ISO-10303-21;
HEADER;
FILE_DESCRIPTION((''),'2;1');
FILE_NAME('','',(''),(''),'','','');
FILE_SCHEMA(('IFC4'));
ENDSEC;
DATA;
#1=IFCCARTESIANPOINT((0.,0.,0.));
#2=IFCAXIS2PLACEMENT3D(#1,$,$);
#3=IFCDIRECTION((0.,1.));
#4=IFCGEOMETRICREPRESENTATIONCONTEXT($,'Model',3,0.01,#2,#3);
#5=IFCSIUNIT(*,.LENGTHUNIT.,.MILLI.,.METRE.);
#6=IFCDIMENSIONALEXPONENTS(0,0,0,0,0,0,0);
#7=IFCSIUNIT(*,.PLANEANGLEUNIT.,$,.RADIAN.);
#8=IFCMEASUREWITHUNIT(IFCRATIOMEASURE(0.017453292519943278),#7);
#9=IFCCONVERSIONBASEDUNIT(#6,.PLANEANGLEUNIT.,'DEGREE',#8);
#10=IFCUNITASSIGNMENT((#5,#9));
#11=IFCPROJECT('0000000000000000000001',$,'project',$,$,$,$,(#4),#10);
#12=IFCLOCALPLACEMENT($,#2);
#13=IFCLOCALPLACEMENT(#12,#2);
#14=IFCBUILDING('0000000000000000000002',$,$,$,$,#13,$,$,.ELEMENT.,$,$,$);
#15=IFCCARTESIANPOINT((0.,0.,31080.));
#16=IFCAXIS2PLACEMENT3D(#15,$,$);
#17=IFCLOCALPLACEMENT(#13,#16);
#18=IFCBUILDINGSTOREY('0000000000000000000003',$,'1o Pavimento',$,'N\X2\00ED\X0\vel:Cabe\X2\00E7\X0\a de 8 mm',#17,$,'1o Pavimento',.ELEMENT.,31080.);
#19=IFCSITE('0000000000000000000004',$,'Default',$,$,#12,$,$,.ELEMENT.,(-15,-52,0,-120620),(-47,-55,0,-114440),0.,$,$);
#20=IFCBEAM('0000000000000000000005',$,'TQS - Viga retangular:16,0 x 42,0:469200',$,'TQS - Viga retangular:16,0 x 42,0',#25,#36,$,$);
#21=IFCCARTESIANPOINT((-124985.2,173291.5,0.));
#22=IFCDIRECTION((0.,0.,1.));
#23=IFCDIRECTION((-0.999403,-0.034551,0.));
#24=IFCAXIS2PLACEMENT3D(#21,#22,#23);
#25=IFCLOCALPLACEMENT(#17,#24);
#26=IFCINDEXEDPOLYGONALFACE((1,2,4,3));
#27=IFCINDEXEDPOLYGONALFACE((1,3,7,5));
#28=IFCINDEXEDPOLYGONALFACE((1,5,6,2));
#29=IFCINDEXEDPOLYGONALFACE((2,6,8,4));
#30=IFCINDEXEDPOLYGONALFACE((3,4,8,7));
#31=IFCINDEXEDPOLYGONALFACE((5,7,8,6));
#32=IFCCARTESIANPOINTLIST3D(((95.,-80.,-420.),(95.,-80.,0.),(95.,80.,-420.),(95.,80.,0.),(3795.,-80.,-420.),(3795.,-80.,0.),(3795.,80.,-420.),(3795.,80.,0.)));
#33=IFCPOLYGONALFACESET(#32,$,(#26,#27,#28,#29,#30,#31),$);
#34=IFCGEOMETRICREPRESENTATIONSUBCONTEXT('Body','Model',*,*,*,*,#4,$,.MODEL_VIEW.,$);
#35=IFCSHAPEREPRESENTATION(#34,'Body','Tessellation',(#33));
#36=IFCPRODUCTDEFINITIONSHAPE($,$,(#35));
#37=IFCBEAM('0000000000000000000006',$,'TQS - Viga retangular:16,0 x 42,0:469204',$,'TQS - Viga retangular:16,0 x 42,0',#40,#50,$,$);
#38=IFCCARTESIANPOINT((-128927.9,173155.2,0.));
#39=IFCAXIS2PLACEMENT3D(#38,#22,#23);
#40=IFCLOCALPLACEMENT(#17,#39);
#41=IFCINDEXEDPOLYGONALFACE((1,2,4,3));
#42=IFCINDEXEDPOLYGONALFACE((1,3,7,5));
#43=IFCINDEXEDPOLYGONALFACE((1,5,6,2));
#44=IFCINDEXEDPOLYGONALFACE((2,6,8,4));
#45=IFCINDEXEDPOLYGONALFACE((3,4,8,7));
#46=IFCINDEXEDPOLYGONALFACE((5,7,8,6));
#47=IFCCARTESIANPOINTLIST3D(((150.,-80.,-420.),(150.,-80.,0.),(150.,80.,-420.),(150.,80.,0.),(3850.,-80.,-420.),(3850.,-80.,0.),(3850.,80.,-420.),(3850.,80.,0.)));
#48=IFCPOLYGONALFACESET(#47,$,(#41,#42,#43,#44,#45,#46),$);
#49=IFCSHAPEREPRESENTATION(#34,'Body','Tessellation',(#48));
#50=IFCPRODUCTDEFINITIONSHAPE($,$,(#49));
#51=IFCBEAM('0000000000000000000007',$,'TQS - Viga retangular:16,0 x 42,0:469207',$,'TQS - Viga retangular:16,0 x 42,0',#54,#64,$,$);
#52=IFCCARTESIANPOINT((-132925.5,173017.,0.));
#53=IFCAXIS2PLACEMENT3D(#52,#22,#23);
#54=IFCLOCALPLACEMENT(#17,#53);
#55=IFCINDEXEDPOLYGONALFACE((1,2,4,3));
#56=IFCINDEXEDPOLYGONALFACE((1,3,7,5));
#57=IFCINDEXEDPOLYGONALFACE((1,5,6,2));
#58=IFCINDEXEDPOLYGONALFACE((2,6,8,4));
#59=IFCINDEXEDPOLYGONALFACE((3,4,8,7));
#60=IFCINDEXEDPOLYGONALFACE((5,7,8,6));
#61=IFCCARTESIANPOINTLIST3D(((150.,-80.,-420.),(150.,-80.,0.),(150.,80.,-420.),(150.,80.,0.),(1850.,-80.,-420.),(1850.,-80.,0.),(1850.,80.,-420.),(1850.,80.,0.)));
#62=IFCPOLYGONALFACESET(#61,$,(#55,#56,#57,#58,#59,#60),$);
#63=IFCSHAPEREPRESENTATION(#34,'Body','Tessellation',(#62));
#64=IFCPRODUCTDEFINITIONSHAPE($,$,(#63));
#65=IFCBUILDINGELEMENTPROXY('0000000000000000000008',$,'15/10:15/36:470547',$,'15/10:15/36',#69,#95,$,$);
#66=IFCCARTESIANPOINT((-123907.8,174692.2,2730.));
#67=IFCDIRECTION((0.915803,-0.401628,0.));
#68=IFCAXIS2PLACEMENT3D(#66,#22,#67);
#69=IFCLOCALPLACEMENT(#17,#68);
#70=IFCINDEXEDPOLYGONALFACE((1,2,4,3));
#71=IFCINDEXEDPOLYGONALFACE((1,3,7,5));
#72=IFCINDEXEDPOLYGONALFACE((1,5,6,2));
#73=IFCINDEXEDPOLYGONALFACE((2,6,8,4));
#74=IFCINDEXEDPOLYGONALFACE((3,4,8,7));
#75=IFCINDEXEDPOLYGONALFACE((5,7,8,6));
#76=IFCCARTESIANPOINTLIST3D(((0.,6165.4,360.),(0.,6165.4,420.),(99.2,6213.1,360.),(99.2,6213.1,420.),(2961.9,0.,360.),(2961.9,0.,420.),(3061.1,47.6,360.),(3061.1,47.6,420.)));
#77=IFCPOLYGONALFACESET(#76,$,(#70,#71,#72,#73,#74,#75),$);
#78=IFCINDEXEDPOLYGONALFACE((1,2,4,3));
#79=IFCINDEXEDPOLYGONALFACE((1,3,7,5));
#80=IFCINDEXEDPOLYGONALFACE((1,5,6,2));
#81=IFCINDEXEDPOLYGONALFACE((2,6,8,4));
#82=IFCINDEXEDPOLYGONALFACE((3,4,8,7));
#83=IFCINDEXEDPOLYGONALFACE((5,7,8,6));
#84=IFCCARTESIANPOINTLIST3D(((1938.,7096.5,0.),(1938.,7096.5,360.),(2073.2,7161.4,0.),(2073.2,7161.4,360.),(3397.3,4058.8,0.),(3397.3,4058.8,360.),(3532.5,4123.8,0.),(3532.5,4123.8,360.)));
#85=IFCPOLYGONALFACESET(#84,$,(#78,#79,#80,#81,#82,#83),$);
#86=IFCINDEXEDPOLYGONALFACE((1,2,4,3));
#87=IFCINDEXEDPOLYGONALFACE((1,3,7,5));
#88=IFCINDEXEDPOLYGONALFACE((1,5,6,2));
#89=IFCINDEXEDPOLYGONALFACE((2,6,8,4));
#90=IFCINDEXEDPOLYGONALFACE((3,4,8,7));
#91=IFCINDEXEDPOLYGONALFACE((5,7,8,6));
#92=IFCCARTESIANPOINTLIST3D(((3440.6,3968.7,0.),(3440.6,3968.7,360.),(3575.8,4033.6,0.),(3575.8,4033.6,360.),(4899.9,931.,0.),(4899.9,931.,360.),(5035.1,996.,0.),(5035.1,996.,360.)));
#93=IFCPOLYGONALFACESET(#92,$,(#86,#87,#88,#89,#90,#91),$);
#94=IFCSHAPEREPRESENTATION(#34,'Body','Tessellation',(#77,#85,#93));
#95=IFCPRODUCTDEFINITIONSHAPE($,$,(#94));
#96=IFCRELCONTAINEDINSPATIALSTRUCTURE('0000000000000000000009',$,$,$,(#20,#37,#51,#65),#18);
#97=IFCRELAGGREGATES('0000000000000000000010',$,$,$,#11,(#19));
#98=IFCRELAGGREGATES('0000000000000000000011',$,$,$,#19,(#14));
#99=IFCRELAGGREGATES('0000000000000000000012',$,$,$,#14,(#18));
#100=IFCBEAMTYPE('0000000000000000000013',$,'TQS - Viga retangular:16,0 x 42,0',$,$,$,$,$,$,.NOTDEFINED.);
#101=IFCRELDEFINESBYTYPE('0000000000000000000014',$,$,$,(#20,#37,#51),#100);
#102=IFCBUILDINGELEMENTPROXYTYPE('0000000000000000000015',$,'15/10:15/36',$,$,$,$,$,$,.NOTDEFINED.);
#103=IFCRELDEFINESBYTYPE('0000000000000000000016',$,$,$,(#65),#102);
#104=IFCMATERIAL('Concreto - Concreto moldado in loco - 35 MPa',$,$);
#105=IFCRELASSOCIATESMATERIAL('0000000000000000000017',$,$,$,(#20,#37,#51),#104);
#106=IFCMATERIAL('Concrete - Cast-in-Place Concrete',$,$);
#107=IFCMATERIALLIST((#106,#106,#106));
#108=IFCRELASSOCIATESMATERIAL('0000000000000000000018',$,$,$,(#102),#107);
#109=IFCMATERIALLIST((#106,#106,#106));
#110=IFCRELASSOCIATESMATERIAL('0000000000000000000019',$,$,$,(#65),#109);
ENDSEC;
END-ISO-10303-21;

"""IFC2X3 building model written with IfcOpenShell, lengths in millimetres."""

from ifc_helpers import new_model, entity, si_unit, converted_unit, direction, frame, frame_2d, origin, origin_2d_with_axis, place, context, subcontext, project, spatial, rectangle, extrude, source, transform, mapped, material, material_list, type_object, type_shapes, element, save


model = new_model("IFC2X3")

# Units and contexts
model_context = context("Model", 3, precision=0.01, world=origin(), true_north=direction((0.0, 1.0)))
body_context = subcontext(model_context, "Body", "Model", "MODEL_VIEW")
ifc_project = project(units=[si_unit("LENGTHUNIT", "METRE", prefix="MILLI"), converted_unit("PLANEANGLEUNIT", "DEGREE", entity("IfcRatioMeasure", 0.017453292519943278), si_unit("PLANEANGLEUNIT", "RADIAN"), dimensions=[0, 0, 0, 0, 0, 0, 0])], contexts=[model_context])

# Site, building, storey
site_placement = place(None, origin())
site = spatial("IfcSite", under=ifc_project, at=site_placement, Name="Default", CompositionType="ELEMENT", RefLatitude=(-15, -52, 0, -120620), RefLongitude=(-47, -55, 0, -114440), RefElevation=0.0)
building_placement = place(site_placement, origin())
building = spatial("IfcBuilding", under=site, at=building_placement, CompositionType="ELEMENT")
storey_placement = place(building_placement, frame((0.0, 0.0, 31080.0)))
storey = spatial("IfcBuildingStorey", under=building, at=storey_placement, Name="1o Pavimento", ObjectType="Nível:Cabeça de 8 mm", LongName="1o Pavimento", CompositionType="ELEMENT", Elevation=31080.0)

# Beams
ifc_material_1 = material(Name="Concreto - Concreto moldado in loco - 35 MPa")
beam_type_1 = type_object("IfcBeamType", Name="TQS - Viga retangular:16,0 x 42,0", PredefinedType="NOTDEFINED")
beam_1_placement = place(storey_placement, frame((-124985.2, 173291.5, 0.0), z_axis=(0.0, 0.0, 1.0), x_axis=(-0.999403, -0.034551, 0.0)))
element("IfcBeam", 1, at=beam_1_placement, inside=storey, type_object=beam_type_1, material=ifc_material_1, Name="TQS - Viga retangular:16,0 x 42,0:469200", ObjectType="TQS - Viga retangular:16,0 x 42,0", context=body_context, shape_type="SweptSolid", body=[
    extrude(rectangle(XDim=420.0, YDim=160.0, at=frame_2d((0.0, 0.0), x_axis=(1.0, 0.0))), frame((95.0, 0.0, -210.0), z_axis=(1.0, 0.0, 0.0), x_axis=(0.0, 0.0, -1.0)), (0.0, 0.0, 1.0), 3700.0),
])
beam_2_placement = place(storey_placement, frame((-128927.9, 173155.2, 0.0), z_axis=(0.0, 0.0, 1.0), x_axis=(-0.999403, -0.034551, 0.0)))
element("IfcBeam", 2, at=beam_2_placement, inside=storey, type_object=beam_type_1, material=ifc_material_1, Name="TQS - Viga retangular:16,0 x 42,0:469204", ObjectType="TQS - Viga retangular:16,0 x 42,0", context=body_context, shape_type="SweptSolid", body=[
    extrude(rectangle(XDim=420.0, YDim=160.0, at=origin_2d_with_axis()), frame((150.0, 0.0, -210.0), z_axis=(1.0, 0.0, 0.0), x_axis=(0.0, 0.0, -1.0)), (0.0, 0.0, 1.0), 3700.0),
])
beam_3_placement = place(storey_placement, frame((-132925.5, 173017.0, 0.0), z_axis=(0.0, 0.0, 1.0), x_axis=(-0.999403, -0.034551, 0.0)))
element("IfcBeam", 3, at=beam_3_placement, inside=storey, type_object=beam_type_1, material=ifc_material_1, Name="TQS - Viga retangular:16,0 x 42,0:469207", ObjectType="TQS - Viga retangular:16,0 x 42,0", context=body_context, shape_type="SweptSolid", body=[
    extrude(rectangle(XDim=420.0, YDim=160.0, at=frame_2d((0.0, 0.0), x_axis=(1.0, 0.0))), frame((150.0, 0.0, -210.0), z_axis=(1.0, 0.0, 0.0), x_axis=(0.0, 0.0, -1.0)), (0.0, 0.0, 1.0), 1700.0),
])

# Building element proxy
ifc_material_2 = material(Name="Concrete - Cast-in-Place Concrete")
ifc_material_list_1 = material_list([ifc_material_2, ifc_material_2, ifc_material_2])
ifc_material_list_2 = material_list([ifc_material_2, ifc_material_2, ifc_material_2])
building_element_proxy_type_1 = type_object("IfcBuildingElementProxyType", Name="15/10:15/36", PredefinedType="NOTDEFINED", material=ifc_material_list_2)
shared_shape_1 = source(origin(), body_context, "Body", "SweptSolid", [
    extrude(rectangle(XDim=110.0, YDim=6840.0, at=frame_2d((0.0, 0.0), x_axis=(1.0, 0.0))), frame((1530.5, 3106.5, 360.0), z_axis=(0.0, 0.0, 1.0), x_axis=(0.90138, 0.43303, 0.0)), (0.0, 0.0, 1.0), 60.0),
    extrude(rectangle(XDim=3370.0, YDim=150.0, at=frame_2d((0.0, 0.0), x_axis=(1.0, 0.0))), frame((2735.2, 5610.1, 0.0), z_axis=(0.0, 0.0, 1.0), x_axis=(0.43303, -0.90138, 0.0)), (0.0, 0.0, 1.0), 360.0),
    extrude(rectangle(XDim=3370.0, YDim=150.0, at=frame_2d((0.0, 0.0), x_axis=(1.0, 0.0))), frame((4237.8, 2482.3, 0.0), z_axis=(0.0, 0.0, 1.0), x_axis=(0.43303, -0.90138, 0.0)), (0.0, 0.0, 1.0), 360.0),
])
type_shapes(building_element_proxy_type_1, [shared_shape_1])
proxy_1_placement = place(storey_placement, frame((-123907.8, 174692.2, 2730.0), z_axis=(0.0, 0.0, 1.0), x_axis=(0.915803, -0.401628, 0.0)))
element("IfcBuildingElementProxy", 4, at=proxy_1_placement, inside=storey, type_object=building_element_proxy_type_1, material=ifc_material_list_1, Name="15/10:15/36:470547", ObjectType="15/10:15/36", context=body_context, shape_type="MappedRepresentation", body=[
    mapped(shared_shape_1, transform((0.0, 0.0, 0.0), scale=1.0)),
])

save(model, "model.ifc")
